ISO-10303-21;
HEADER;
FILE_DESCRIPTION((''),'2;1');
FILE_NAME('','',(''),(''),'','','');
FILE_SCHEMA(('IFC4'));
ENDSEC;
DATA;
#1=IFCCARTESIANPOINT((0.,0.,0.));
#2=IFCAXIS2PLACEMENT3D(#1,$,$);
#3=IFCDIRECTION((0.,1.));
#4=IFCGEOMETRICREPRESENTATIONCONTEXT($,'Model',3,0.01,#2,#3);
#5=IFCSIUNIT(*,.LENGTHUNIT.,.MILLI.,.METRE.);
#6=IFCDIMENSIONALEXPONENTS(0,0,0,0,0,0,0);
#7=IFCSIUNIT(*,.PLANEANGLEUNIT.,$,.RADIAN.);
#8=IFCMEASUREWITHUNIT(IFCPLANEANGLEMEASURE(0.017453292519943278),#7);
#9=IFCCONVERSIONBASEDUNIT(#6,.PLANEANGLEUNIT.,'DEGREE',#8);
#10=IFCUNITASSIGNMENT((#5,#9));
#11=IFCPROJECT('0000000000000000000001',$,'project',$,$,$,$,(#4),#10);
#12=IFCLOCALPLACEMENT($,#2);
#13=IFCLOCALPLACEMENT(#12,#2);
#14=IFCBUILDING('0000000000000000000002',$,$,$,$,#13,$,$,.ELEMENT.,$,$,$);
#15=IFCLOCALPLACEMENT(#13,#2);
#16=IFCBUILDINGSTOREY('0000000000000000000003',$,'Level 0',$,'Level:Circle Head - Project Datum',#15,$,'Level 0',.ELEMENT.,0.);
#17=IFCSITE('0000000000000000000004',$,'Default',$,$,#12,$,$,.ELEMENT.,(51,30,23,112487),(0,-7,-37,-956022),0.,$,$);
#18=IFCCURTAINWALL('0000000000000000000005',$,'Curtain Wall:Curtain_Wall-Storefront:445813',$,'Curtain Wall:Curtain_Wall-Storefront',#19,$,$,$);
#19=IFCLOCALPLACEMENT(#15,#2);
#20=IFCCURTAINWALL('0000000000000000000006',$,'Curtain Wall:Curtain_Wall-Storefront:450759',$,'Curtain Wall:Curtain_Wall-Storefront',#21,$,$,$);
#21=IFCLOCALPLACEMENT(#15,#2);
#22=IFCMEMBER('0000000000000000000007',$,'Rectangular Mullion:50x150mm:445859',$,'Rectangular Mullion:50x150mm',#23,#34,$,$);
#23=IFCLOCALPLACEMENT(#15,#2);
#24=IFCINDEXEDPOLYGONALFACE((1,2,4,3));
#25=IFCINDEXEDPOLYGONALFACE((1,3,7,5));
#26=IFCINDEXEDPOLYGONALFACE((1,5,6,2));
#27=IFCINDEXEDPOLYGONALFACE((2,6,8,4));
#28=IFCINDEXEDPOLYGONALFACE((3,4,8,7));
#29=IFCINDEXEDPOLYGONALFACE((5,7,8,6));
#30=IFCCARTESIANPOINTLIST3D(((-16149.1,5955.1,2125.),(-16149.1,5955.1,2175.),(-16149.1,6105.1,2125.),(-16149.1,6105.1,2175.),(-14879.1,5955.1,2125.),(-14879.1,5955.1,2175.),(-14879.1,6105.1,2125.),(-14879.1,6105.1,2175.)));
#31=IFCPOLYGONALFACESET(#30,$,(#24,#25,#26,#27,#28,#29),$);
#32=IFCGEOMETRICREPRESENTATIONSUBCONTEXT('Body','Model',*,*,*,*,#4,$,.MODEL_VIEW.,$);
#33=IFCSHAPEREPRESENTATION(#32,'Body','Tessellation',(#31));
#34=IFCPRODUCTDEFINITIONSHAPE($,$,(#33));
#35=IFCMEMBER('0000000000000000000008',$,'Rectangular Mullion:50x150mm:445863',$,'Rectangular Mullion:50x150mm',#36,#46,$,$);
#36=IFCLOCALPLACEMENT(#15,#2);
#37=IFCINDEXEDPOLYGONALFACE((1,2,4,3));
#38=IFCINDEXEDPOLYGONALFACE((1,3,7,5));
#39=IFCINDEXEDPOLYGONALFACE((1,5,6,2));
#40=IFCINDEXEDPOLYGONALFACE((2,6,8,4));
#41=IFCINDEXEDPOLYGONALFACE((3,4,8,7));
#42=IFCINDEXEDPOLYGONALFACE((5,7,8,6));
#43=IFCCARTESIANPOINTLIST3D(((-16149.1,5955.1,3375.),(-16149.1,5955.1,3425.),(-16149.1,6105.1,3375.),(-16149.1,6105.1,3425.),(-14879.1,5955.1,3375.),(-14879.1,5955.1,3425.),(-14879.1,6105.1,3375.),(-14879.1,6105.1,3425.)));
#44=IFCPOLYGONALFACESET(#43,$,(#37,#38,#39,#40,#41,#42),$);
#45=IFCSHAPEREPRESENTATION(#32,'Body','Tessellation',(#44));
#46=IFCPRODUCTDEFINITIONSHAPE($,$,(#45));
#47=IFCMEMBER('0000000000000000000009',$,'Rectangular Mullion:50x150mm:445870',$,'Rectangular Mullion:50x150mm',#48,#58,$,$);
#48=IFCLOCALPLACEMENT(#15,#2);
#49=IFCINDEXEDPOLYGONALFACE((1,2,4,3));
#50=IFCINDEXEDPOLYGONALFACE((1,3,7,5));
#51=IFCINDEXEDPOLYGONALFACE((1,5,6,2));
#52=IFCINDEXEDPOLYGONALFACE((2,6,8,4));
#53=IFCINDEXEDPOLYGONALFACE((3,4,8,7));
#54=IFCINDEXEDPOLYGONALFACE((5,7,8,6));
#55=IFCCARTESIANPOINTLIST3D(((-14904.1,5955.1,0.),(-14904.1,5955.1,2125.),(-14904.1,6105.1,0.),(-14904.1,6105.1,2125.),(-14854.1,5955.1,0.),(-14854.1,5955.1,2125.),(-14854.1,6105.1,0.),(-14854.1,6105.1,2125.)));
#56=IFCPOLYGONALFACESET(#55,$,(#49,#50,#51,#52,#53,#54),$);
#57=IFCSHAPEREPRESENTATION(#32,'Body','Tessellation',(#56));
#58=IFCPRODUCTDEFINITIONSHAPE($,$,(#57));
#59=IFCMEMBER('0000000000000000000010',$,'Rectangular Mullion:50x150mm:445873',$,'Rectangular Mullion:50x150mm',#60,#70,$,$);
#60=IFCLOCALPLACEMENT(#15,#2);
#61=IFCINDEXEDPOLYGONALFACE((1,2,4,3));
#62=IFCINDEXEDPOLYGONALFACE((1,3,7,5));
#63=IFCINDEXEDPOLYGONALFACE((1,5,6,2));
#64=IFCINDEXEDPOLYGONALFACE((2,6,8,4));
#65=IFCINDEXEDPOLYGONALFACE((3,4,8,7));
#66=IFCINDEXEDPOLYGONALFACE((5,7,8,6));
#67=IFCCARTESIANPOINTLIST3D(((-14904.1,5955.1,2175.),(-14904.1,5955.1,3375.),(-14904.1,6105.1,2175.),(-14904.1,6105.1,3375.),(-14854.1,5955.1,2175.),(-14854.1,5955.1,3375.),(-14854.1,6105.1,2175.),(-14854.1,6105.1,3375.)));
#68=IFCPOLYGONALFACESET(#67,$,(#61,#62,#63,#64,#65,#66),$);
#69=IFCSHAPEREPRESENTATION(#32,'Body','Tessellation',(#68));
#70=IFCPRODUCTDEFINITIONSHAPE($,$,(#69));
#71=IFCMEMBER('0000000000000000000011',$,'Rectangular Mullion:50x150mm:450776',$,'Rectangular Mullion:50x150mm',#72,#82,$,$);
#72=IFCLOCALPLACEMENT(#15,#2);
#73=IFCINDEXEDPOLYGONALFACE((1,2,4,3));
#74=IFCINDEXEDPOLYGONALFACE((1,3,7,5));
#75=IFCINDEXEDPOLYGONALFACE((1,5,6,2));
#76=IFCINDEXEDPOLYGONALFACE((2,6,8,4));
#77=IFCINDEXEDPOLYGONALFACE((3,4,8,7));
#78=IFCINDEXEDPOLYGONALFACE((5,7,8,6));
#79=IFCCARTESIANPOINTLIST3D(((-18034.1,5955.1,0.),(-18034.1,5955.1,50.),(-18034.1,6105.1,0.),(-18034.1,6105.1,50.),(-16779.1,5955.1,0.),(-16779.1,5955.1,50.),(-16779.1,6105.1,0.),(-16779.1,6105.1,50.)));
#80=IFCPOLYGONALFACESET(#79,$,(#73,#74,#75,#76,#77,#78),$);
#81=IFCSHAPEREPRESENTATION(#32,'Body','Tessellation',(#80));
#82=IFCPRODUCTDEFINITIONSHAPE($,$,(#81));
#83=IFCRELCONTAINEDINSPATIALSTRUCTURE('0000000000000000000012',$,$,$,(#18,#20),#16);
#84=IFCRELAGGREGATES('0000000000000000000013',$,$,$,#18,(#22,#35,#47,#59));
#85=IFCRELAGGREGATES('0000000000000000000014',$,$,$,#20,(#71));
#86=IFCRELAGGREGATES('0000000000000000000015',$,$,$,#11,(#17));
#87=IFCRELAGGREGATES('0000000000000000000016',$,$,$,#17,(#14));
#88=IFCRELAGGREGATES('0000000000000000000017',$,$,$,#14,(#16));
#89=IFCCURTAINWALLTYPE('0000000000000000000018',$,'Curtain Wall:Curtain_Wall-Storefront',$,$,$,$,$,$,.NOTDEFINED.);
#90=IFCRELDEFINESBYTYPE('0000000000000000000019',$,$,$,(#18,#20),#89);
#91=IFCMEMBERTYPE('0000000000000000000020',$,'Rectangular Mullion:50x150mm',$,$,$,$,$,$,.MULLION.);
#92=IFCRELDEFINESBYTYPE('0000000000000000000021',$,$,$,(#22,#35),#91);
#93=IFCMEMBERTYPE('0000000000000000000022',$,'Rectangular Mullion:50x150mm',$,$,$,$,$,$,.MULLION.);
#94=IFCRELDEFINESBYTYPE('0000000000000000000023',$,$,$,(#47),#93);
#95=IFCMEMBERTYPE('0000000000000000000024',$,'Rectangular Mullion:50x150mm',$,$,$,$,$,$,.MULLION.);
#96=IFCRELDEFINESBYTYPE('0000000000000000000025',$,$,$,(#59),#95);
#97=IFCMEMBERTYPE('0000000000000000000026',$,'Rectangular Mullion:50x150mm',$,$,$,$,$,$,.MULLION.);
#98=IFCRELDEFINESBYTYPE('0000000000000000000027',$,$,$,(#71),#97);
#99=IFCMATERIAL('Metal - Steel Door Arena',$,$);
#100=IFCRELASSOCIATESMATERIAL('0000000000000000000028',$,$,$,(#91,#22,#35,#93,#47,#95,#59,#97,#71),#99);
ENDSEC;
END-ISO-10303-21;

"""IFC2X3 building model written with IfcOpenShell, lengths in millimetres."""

from ifc_helpers import new_model, entity, si_unit, converted_unit, direction, frame, origin, origin_2d_with_axis, place, context, subcontext, project, spatial, rectangle, extrude, source, transform, mapped, material, type_object, type_shapes, element, aggregate, save


model = new_model("IFC2X3")

# Units and contexts
model_context = context("Model", 3, precision=0.01, world=origin(), true_north=direction((0.0, 1.0)))
body_context = subcontext(model_context, "Body", "Model", "MODEL_VIEW")
ifc_project = project(units=[si_unit("LENGTHUNIT", "METRE", prefix="MILLI"), converted_unit("PLANEANGLEUNIT", "DEGREE", entity("IfcPlaneAngleMeasure", 0.017453292519943278), si_unit("PLANEANGLEUNIT", "RADIAN"), dimensions=[0, 0, 0, 0, 0, 0, 0])], contexts=[model_context])

# Site, building, storey
site_placement = place(None, origin())
site = spatial("IfcSite", under=ifc_project, at=site_placement, Name="Default", CompositionType="ELEMENT", RefLatitude=(51, 30, 23, 112487), RefLongitude=(0, -7, -37, -956022), RefElevation=0.0)
building_placement = place(site_placement, origin())
building = spatial("IfcBuilding", under=site, at=building_placement, CompositionType="ELEMENT")
storey_placement = place(building_placement, origin())
storey = spatial("IfcBuildingStorey", under=building, at=storey_placement, Name="Level 0", ObjectType="Level:Circle Head - Project Datum", LongName="Level 0", CompositionType="ELEMENT", Elevation=0.0)

# Curtain walls
curtain_wall_type = type_object("IfcCurtainWallType", Name="Curtain Wall:Curtain_Wall-Storefront", PredefinedType="NOTDEFINED")
curtain_wall_1_placement = place(storey_placement, origin())
curtain_wall_1 = element("IfcCurtainWall", 1, at=curtain_wall_1_placement, inside=storey, type_object=curtain_wall_type, Name="Curtain Wall:Curtain_Wall-Storefront:445813", ObjectType="Curtain Wall:Curtain_Wall-Storefront")
ifc_material_1 = material(Name="Metal - Steel Door Arena")
curtain_wall_2_placement = place(storey_placement, origin())
curtain_wall_2 = element("IfcCurtainWall", 2, at=curtain_wall_2_placement, inside=storey, type_object=curtain_wall_type, Name="Curtain Wall:Curtain_Wall-Storefront:450759", ObjectType="Curtain Wall:Curtain_Wall-Storefront")

# Members
member_type_1 = type_object("IfcMemberType", Name="Rectangular Mullion:50x150mm", PredefinedType="MULLION", material=ifc_material_1)
shared_shape_1 = source(origin(), body_context, "Body", "SweptSolid", [
    extrude(rectangle(XDim=50.0, YDim=150.0, at=origin_2d_with_axis()), frame((0.0, 0.0, -1270.0), z_axis=(0.0, 0.0, 1.0), x_axis=(-1.0, 0.0, 0.0)), (0.0, 0.0, 1.0), 1270.0),
])
type_shapes(member_type_1, [shared_shape_1])
member_1_placement = place(curtain_wall_1_placement, frame((-16149.1, 6030.1, 2150.0), z_axis=(-1.0, 0.0, 0.0), x_axis=(0.0, 0.0, 1.0)))
member_1 = element("IfcMember", 3, at=member_1_placement, type_object=member_type_1, material=ifc_material_1, Name="Rectangular Mullion:50x150mm:445859", ObjectType="Rectangular Mullion:50x150mm", context=body_context, shape_type="MappedRepresentation", body=[
    mapped(shared_shape_1, transform((0.0, 0.0, 0.0), scale=1.0)),
])
member_2_placement = place(curtain_wall_1_placement, frame((-16149.1, 6030.1, 3400.0), z_axis=(-1.0, 0.0, 0.0), x_axis=(0.0, 0.0, 1.0)))
member_2 = element("IfcMember", 4, at=member_2_placement, type_object=member_type_1, material=ifc_material_1, Name="Rectangular Mullion:50x150mm:445863", ObjectType="Rectangular Mullion:50x150mm", context=body_context, shape_type="MappedRepresentation", body=[
    mapped(shared_shape_1, transform((0.0, 0.0, 0.0), scale=1.0)),
])
member_type_2 = type_object("IfcMemberType", Name="Rectangular Mullion:50x150mm", PredefinedType="MULLION", material=ifc_material_1)
shared_shape_2 = source(origin(), body_context, "Body", "SweptSolid", [
    extrude(rectangle(XDim=50.0, YDim=150.0, at=origin_2d_with_axis()), frame((0.0, 0.0, -2125.0), z_axis=(0.0, 0.0, 1.0), x_axis=(-1.0, 0.0, 0.0)), (0.0, 0.0, 1.0), 2125.0),
])
type_shapes(member_type_2, [shared_shape_2])
member_3_placement = place(curtain_wall_1_placement, frame((-14879.1, 6030.1, 0.0), z_axis=(0.0, 0.0, -1.0), x_axis=(-1.0, 0.0, 0.0)))
member_3 = element("IfcMember", 5, at=member_3_placement, type_object=member_type_2, material=ifc_material_1, Name="Rectangular Mullion:50x150mm:445870", ObjectType="Rectangular Mullion:50x150mm", context=body_context, shape_type="MappedRepresentation", body=[
    mapped(shared_shape_2, transform((0.0, 0.0, 0.0), scale=1.0)),
])
member_type_3 = type_object("IfcMemberType", Name="Rectangular Mullion:50x150mm", PredefinedType="MULLION", material=ifc_material_1)
shared_shape_3 = source(origin(), body_context, "Body", "SweptSolid", [
    extrude(rectangle(XDim=50.0, YDim=150.0, at=origin_2d_with_axis()), frame((0.0, 0.0, -1200.0), z_axis=(0.0, 0.0, 1.0), x_axis=(-1.0, 0.0, 0.0)), (0.0, 0.0, 1.0), 1200.0),
])
type_shapes(member_type_3, [shared_shape_3])
member_4_placement = place(curtain_wall_1_placement, frame((-14879.1, 6030.1, 2175.0), z_axis=(0.0, 0.0, -1.0), x_axis=(-1.0, 0.0, 0.0)))
member_4 = element("IfcMember", 6, at=member_4_placement, type_object=member_type_3, material=ifc_material_1, Name="Rectangular Mullion:50x150mm:445873", ObjectType="Rectangular Mullion:50x150mm", context=body_context, shape_type="MappedRepresentation", body=[
    mapped(shared_shape_3, transform((0.0, 0.0, 0.0), scale=1.0)),
])
member_type_4 = type_object("IfcMemberType", Name="Rectangular Mullion:50x150mm", PredefinedType="MULLION", material=ifc_material_1)
shared_shape_4 = source(origin(), body_context, "Body", "SweptSolid", [
    extrude(rectangle(XDim=50.0, YDim=150.0, at=origin_2d_with_axis()), frame((-25.0, 0.0, -1255.0), z_axis=(0.0, 0.0, 1.0), x_axis=(-1.0, 0.0, 0.0)), (0.0, 0.0, 1.0), 1255.0),
])
type_shapes(member_type_4, [shared_shape_4])
member_5_placement = place(curtain_wall_2_placement, frame((-16779.1, 6030.1, 0.0), z_axis=(1.0, 0.0, 0.0), x_axis=(0.0, 0.0, -1.0)))
member_5 = element("IfcMember", 7, at=member_5_placement, type_object=member_type_4, material=ifc_material_1, Name="Rectangular Mullion:50x150mm:450776", ObjectType="Rectangular Mullion:50x150mm", context=body_context, shape_type="MappedRepresentation", body=[
    mapped(shared_shape_4, transform((0.0, 0.0, 0.0), scale=1.0)),
])

aggregate(curtain_wall_1, [member_1, member_2, member_3, member_4])
aggregate(curtain_wall_2, [member_5])

save(model, "model.ifc")
